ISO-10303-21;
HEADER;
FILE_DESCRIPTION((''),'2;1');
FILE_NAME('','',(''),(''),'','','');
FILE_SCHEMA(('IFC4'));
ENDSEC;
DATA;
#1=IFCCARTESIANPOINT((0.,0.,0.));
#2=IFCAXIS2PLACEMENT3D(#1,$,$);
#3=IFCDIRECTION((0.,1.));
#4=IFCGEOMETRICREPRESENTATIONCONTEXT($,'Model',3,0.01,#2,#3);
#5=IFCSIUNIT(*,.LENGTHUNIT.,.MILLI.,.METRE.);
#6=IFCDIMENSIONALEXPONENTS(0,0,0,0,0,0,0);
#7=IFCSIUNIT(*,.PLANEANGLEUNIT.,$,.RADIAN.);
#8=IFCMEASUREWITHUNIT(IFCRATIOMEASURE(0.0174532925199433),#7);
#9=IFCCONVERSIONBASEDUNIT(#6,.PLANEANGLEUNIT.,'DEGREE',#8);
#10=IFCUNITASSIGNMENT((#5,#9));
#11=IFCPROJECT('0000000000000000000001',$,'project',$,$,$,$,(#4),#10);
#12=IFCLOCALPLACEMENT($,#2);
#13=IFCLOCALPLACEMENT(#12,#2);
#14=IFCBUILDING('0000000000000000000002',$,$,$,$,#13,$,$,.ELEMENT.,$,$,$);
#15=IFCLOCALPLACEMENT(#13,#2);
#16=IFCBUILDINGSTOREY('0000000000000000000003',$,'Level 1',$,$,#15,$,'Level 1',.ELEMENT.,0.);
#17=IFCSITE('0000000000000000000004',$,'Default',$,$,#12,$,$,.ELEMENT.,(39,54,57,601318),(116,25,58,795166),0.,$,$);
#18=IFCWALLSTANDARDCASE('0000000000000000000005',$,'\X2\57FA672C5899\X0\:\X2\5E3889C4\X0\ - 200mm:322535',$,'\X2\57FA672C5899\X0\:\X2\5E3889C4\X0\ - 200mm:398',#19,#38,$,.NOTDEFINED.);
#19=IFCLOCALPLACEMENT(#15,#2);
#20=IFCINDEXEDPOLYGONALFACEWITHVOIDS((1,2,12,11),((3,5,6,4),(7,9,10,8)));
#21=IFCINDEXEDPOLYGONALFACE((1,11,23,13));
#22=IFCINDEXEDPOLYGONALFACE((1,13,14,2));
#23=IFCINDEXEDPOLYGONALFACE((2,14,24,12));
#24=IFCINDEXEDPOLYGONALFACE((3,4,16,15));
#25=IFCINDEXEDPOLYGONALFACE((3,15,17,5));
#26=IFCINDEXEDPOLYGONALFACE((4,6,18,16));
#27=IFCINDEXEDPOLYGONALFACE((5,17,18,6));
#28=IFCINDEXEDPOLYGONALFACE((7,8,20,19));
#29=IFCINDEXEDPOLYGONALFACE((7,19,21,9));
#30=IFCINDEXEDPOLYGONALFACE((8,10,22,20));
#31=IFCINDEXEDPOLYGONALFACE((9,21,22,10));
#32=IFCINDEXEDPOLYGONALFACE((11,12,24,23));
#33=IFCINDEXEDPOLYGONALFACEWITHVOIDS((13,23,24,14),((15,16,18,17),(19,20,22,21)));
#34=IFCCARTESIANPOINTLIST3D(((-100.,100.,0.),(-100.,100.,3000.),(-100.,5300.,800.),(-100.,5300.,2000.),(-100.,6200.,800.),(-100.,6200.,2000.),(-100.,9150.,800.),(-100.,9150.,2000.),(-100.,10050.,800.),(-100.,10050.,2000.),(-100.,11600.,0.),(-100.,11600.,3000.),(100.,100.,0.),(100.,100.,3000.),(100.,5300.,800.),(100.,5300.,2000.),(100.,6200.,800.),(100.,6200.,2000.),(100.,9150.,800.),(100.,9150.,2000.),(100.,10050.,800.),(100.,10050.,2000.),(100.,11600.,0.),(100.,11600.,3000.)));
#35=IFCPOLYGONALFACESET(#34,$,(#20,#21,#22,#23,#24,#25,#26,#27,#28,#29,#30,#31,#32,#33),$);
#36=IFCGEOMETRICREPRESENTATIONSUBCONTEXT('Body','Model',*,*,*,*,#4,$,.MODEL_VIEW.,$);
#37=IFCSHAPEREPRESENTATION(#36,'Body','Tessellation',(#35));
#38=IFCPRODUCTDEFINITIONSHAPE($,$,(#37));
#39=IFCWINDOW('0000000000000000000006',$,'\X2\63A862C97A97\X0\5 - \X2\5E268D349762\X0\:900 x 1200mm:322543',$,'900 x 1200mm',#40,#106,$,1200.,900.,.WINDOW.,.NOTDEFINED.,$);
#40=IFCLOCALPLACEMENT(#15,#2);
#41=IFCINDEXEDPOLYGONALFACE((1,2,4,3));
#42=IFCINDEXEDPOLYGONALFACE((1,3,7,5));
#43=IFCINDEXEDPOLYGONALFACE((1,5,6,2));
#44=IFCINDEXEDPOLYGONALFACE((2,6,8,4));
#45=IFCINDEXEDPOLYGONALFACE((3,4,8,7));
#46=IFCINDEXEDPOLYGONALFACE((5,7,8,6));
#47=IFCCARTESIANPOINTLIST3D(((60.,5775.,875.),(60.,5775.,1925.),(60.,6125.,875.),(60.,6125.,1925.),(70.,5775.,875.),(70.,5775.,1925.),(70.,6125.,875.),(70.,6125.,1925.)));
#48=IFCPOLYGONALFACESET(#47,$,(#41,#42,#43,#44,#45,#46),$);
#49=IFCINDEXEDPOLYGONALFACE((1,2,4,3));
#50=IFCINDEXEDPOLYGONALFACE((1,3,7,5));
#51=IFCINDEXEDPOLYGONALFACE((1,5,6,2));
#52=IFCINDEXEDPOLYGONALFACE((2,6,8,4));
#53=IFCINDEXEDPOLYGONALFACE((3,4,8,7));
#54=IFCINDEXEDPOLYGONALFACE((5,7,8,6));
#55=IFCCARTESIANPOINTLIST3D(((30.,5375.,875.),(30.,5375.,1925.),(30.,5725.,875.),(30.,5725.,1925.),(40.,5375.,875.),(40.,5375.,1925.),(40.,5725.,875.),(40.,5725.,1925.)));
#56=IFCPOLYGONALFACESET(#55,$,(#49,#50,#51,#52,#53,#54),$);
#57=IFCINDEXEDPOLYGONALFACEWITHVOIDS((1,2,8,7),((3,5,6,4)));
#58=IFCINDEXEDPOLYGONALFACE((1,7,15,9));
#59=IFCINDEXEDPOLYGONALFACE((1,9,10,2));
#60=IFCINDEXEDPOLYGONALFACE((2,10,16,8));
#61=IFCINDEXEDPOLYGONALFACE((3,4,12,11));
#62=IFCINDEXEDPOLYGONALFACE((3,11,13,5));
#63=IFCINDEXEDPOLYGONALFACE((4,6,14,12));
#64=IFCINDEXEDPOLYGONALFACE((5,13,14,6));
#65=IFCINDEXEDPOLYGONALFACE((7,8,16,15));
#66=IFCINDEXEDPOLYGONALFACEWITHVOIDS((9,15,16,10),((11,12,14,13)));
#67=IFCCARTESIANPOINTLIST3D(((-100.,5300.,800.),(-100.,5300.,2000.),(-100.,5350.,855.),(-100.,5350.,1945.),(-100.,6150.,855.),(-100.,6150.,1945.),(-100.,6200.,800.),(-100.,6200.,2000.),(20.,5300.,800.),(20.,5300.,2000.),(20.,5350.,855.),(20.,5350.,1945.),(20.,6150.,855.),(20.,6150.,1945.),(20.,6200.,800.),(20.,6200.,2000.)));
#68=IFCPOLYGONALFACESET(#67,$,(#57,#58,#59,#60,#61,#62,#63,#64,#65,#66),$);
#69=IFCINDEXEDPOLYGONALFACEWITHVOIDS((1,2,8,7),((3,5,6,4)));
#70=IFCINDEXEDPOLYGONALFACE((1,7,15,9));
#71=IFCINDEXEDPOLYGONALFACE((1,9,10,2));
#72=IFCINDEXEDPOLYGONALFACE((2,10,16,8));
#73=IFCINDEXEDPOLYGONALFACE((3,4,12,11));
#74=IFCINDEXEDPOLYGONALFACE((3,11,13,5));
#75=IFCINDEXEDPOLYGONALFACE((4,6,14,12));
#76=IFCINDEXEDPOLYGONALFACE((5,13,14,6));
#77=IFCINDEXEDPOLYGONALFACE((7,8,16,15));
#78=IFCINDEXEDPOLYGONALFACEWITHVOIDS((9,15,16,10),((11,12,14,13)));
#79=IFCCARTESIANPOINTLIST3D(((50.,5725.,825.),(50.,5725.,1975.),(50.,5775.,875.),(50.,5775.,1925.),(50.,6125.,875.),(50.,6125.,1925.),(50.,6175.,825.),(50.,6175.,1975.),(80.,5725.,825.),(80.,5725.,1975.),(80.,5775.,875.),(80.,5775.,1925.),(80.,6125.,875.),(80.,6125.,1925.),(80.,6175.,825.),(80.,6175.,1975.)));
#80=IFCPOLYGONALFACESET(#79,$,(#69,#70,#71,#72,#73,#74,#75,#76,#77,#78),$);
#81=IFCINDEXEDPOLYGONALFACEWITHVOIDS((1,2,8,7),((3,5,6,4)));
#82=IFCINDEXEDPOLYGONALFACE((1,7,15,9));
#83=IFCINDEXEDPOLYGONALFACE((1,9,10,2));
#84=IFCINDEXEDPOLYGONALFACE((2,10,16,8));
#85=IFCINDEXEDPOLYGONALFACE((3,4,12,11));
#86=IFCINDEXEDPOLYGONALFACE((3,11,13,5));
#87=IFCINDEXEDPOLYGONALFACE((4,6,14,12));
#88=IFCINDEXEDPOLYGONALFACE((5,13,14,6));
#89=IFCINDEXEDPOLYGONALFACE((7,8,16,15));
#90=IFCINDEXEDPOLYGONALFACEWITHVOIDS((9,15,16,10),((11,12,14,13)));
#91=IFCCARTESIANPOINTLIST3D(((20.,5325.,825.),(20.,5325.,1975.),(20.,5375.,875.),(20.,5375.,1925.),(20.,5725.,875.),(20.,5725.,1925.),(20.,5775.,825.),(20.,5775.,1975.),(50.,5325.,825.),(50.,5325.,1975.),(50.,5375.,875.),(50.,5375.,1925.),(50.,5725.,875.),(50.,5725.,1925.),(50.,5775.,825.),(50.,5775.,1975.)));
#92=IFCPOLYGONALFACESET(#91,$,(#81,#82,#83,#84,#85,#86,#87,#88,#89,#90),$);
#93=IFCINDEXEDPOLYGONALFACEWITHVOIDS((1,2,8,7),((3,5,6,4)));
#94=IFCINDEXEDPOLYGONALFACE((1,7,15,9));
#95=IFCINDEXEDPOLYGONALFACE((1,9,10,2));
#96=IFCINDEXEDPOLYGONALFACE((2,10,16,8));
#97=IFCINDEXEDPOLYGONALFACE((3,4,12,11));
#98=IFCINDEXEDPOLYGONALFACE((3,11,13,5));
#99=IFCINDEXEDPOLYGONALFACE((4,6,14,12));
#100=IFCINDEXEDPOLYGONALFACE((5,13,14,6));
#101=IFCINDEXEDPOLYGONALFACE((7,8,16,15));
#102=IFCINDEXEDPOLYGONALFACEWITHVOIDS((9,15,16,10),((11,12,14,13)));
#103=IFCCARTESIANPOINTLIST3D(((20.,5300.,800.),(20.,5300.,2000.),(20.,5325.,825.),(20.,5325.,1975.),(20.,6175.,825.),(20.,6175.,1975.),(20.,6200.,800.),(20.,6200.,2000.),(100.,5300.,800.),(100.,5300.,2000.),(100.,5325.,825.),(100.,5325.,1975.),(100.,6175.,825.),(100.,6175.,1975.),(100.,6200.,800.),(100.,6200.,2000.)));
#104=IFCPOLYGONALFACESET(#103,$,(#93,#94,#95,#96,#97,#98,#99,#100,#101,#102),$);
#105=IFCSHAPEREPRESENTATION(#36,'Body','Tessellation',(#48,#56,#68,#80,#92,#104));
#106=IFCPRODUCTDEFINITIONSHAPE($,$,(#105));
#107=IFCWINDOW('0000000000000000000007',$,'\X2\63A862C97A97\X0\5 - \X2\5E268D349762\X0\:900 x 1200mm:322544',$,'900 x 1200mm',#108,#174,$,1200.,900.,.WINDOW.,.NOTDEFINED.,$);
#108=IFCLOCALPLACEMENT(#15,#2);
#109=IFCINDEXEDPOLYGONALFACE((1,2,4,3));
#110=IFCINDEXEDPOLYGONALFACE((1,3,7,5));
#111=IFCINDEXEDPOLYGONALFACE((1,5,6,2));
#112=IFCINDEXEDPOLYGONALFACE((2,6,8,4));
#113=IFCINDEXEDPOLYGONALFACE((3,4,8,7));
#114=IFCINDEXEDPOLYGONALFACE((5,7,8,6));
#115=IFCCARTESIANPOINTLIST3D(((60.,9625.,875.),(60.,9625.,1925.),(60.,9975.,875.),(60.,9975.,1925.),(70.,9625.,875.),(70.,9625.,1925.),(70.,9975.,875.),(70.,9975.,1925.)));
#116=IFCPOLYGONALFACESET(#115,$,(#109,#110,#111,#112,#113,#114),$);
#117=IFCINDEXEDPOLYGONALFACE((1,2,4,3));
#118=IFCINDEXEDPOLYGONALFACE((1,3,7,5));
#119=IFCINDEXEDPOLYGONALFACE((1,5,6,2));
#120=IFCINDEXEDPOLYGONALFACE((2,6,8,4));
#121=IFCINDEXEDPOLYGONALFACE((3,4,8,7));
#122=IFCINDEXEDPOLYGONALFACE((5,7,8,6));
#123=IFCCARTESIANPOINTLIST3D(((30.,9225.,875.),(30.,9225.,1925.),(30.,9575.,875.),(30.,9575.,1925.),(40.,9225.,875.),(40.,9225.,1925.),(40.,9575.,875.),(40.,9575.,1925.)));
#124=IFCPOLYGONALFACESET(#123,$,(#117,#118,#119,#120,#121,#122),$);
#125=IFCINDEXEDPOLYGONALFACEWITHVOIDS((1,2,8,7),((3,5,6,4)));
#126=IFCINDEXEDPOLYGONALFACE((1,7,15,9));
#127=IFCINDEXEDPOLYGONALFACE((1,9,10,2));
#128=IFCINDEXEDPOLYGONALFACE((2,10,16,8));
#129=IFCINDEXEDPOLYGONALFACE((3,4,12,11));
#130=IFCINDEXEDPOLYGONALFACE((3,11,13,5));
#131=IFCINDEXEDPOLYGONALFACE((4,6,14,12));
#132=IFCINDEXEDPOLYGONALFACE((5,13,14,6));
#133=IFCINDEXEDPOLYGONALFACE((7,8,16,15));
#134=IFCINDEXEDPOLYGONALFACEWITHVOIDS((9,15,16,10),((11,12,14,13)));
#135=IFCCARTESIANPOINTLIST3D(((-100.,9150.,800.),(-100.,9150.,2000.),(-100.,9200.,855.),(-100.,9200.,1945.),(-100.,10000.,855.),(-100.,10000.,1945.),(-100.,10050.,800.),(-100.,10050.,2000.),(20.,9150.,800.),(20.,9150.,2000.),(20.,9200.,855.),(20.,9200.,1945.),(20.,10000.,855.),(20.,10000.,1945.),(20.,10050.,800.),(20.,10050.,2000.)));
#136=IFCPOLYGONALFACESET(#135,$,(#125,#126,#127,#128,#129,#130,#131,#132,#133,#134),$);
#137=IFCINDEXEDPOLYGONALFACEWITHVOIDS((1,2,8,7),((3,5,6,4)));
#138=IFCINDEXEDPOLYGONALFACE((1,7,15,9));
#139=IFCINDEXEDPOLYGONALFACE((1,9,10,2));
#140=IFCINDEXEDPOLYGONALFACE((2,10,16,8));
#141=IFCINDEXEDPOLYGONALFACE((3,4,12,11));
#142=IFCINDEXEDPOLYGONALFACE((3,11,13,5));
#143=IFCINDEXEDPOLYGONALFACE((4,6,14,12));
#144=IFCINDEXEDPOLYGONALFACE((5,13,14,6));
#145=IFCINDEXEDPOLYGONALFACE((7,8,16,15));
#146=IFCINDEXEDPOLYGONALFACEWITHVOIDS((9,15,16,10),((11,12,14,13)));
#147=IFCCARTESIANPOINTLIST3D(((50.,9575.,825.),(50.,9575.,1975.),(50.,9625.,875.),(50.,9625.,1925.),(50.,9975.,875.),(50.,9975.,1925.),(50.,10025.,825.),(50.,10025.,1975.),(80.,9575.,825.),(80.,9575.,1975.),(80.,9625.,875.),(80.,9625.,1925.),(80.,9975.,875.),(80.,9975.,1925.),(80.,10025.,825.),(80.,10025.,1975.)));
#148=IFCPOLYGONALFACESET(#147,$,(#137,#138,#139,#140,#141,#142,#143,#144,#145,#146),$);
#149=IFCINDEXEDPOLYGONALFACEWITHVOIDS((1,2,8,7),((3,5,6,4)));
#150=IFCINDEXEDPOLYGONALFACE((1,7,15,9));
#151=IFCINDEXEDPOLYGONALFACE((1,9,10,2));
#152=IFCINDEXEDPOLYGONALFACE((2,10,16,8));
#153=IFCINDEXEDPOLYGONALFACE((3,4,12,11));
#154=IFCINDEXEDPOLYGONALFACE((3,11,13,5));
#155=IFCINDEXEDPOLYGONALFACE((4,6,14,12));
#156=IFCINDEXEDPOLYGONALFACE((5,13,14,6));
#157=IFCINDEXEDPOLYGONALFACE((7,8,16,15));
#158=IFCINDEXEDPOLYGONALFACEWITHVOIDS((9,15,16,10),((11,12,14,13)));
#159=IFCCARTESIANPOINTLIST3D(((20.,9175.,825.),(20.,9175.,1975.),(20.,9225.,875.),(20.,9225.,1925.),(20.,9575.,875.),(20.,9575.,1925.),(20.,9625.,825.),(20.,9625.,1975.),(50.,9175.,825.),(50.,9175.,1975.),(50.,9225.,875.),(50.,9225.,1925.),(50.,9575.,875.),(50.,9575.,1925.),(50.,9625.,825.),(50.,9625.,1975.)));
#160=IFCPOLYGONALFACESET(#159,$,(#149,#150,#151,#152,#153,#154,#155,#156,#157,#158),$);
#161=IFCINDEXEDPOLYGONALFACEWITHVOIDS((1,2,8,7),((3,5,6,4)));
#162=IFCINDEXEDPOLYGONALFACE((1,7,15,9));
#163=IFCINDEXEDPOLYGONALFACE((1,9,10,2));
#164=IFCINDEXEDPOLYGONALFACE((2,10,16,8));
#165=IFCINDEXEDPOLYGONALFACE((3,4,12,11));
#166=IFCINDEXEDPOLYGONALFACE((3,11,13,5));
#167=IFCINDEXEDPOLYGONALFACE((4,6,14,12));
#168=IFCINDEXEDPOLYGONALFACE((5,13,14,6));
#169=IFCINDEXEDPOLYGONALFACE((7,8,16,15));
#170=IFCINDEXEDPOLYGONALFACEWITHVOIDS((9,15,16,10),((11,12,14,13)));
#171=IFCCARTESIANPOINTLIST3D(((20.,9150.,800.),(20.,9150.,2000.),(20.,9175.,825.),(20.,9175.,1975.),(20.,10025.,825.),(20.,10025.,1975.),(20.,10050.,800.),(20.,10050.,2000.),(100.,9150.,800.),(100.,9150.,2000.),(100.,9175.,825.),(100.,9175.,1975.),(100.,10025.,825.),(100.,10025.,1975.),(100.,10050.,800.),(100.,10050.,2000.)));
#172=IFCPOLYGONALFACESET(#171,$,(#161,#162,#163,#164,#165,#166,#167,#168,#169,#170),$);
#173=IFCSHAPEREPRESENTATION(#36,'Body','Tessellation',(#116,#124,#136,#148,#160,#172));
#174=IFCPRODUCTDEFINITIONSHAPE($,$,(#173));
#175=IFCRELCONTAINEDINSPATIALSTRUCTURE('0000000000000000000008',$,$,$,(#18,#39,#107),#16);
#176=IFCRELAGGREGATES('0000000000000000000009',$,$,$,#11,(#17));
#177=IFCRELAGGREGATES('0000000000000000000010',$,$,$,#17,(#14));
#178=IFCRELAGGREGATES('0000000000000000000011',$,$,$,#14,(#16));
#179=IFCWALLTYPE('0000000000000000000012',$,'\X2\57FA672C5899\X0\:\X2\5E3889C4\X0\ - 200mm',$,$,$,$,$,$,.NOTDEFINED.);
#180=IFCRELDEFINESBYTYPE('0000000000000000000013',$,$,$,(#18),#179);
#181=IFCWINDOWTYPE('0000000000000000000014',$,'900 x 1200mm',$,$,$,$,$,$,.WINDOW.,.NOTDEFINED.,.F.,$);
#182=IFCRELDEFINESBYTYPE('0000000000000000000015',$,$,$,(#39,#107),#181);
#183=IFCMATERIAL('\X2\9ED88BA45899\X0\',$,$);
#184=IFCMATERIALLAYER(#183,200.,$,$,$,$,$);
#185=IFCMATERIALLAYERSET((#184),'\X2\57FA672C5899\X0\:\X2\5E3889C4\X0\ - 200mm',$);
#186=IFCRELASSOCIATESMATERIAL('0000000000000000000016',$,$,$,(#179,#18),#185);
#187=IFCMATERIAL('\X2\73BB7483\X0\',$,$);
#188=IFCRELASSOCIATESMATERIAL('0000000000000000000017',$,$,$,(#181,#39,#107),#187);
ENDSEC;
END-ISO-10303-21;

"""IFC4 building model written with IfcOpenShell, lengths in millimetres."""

from ifc_helpers import new_model, entity, si_unit, converted_unit, direction, frame, frame_2d, origin, origin_2d_with_axis, place, context, subcontext, project, spatial, polyline, rectangle, outline, extrude, source, transform, mapped, material, layer, layer_set, layer_usage, type_object, type_shapes, element, fill, save


model = new_model("IFC4")

# Units and contexts
model_context = context("Model", 3, precision=0.01, world=origin(), true_north=direction((0.0, 1.0)))
body_context = subcontext(model_context, "Body", "Model", "MODEL_VIEW")
ifc_project = project(units=[si_unit("LENGTHUNIT", "METRE", prefix="MILLI"), converted_unit("PLANEANGLEUNIT", "DEGREE", entity("IfcRatioMeasure", 0.0174532925199433), si_unit("PLANEANGLEUNIT", "RADIAN"), dimensions=[0, 0, 0, 0, 0, 0, 0])], contexts=[model_context])

# Site, building, storey
site_placement = place(None, origin())
site = spatial("IfcSite", under=ifc_project, at=site_placement, Name="Default", CompositionType="ELEMENT", RefLatitude=(39, 54, 57, 601318), RefLongitude=(116, 25, 58, 795166), RefElevation=0.0)
building_placement = place(site_placement, origin())
building = spatial("IfcBuilding", under=site, at=building_placement, CompositionType="ELEMENT")
storey_placement = place(building_placement, origin())
storey = spatial("IfcBuildingStorey", under=building, at=storey_placement, Name="Level 1", LongName="Level 1", CompositionType="ELEMENT", Elevation=0.0)

# Shared definitions
ifc_material_1 = material(Name="默认墙")
ifc_layer_1 = layer(ifc_material_1, 200.0)
ifc_layer_set_1 = layer_set([ifc_layer_1], Name="基本墙:常规 - 200mm")
wall_type = type_object("IfcWallType", Name="基本墙:常规 - 200mm", PredefinedType="NOTDEFINED", material=ifc_layer_set_1)
ifc_material_2 = material(Name="玻璃")

# Wall, openings, windows
ifc_layer_usage_1 = layer_usage(ifc_layer_set_1, "AXIS2", "NEGATIVE", 100.0)
wall_1_placement = place(storey_placement, frame((0.0, 100.0, 0.0), z_axis=(0.0, 0.0, 1.0), x_axis=(0.0, 1.0, 0.0)))
wall_1 = element("IfcWallStandardCase", 1, at=wall_1_placement, inside=storey, type_object=wall_type, material=ifc_layer_usage_1, Name="基本墙:常规 - 200mm:322535", ObjectType="基本墙:常规 - 200mm:398", PredefinedType="NOTDEFINED", context=body_context, shape_type="SweptSolid", body=[
    extrude(rectangle(XDim=11500.0, YDim=200.0, at=frame_2d((5750.0, 0.0), x_axis=(-1.0, 0.0))), origin(), (0.0, 0.0, 1.0), 3000.0),
])
opening_1_placement = place(wall_1_placement, frame((6100.0, 100.0, 800.0)))
opening_1 = element("IfcOpeningElement", 2, at=opening_1_placement, cuts=wall_1, ObjectType="Opening", PredefinedType="OPENING", context=body_context, shape_type="SweptSolid", body=[
    extrude(rectangle(XDim=1200.0, YDim=900.0, at=frame_2d((600.0, 450.0), x_axis=(-1.0, 0.0))), frame((0.0, 0.0, 0.0), z_axis=(0.0, -1.0, 0.0), x_axis=(0.0, 0.0, 1.0)), (0.0, 0.0, 1.0), 200.0),
])
opening_2_placement = place(wall_1_placement, frame((9950.0, 100.0, 800.0)))
opening_2 = element("IfcOpeningElement", 3, at=opening_2_placement, cuts=wall_1, ObjectType="Opening", PredefinedType="OPENING", context=body_context, shape_type="SweptSolid", body=[
    extrude(rectangle(XDim=1200.0, YDim=900.0, at=frame_2d((600.0, 450.0), x_axis=(-1.0, 0.0))), frame((0.0, 0.0, 0.0), z_axis=(0.0, -1.0, 0.0), x_axis=(0.0, 0.0, 1.0)), (0.0, 0.0, 1.0), 200.0),
])
window_type_1 = type_object("IfcWindowType", Name="900 x 1200mm", ParameterTakesPrecedence=False, PartitioningType="NOTDEFINED", PredefinedType="WINDOW", material=ifc_material_2)
shared_shape_1 = source(origin(), body_context, "Body", "SweptSolid", [
    extrude(rectangle(XDim=10.0, YDim=350.0, at=origin_2d_with_axis()), frame((250.0, 165.0, 75.0), z_axis=(0.0, 0.0, 1.0), x_axis=(0.0, -1.0, 0.0)), (0.0, 0.0, 1.0), 1050.0),
    extrude(rectangle(XDim=10.0, YDim=350.0, at=origin_2d_with_axis()), frame((650.0, 135.0, 75.0), z_axis=(0.0, 0.0, 1.0), x_axis=(0.0, -1.0, 0.0)), (0.0, 0.0, 1.0), 1050.0),
    extrude(outline(polyline([(-450.0, -600.0), (450.0, -600.0), (450.0, 600.0), (-450.0, 600.0), (-450.0, -600.0)]), holes=[polyline([(400.0, -545.0), (-400.0, -545.0), (-400.0, 545.0), (400.0, 545.0), (400.0, -545.0)])]), frame((450.0, 0.0, 600.0), z_axis=(0.0, 1.0, 0.0), x_axis=(1.0, 0.0, 0.0)), (0.0, 0.0, 1.0), 120.0),
    extrude(outline(polyline([(-225.0, -575.0), (225.0, -575.0), (225.0, 575.0), (-225.0, 575.0), (-225.0, -575.0)]), holes=[polyline([(-175.0, -525.0), (-175.0, 525.0), (175.0, 525.0), (175.0, -525.0), (-175.0, -525.0)])]), frame((250.0, 150.0, 600.0), z_axis=(0.0, 1.0, 0.0), x_axis=(-1.0, 0.0, 0.0)), (0.0, 0.0, 1.0), 30.0),
    extrude(outline(polyline([(-225.0, -575.0), (225.0, -575.0), (225.0, 575.0), (-225.0, 575.0), (-225.0, -575.0)]), holes=[polyline([(-175.0, -525.0), (-175.0, 525.0), (175.0, 525.0), (175.0, -525.0), (-175.0, -525.0)])]), frame((650.0, 120.0, 600.0), z_axis=(0.0, 1.0, 0.0), x_axis=(1.0, 0.0, 0.0)), (0.0, 0.0, 1.0), 30.0),
    extrude(outline(polyline([(-450.0, -600.0), (450.0, -600.0), (450.0, 600.0), (-450.0, 600.0), (-450.0, -600.0)]), holes=[polyline([(-425.0, 575.0), (425.0, 575.0), (425.0, -575.0), (-425.0, -575.0), (-425.0, 575.0)])]), frame((450.0, 120.0, 600.0), z_axis=(0.0, 1.0, 0.0), x_axis=(1.0, 0.0, 0.0)), (0.0, 0.0, 1.0), 80.0),
])
type_shapes(window_type_1, [shared_shape_1])
window_1_placement = place(opening_1_placement, frame((0.0, 0.0, 0.0), z_axis=(0.0, 0.0, 1.0), x_axis=(-1.0, 0.0, 0.0)))
window_1 = element("IfcWindow", 4, at=window_1_placement, inside=storey, type_object=window_type_1, material=ifc_material_2, Name="推拉窗5 - 带贴面:900 x 1200mm:322543", ObjectType="900 x 1200mm", OverallHeight=1200.0, OverallWidth=900.0, PartitioningType="NOTDEFINED", PredefinedType="WINDOW", context=body_context, shape_type="MappedRepresentation", body=[
    mapped(shared_shape_1, transform((0.0, 0.0, 0.0), scale=1.0)),
])
fill(opening_1, window_1)
window_2_placement = place(opening_2_placement, frame((0.0, 0.0, 0.0), z_axis=(0.0, 0.0, 1.0), x_axis=(-1.0, 0.0, 0.0)))
window_2 = element("IfcWindow", 5, at=window_2_placement, inside=storey, type_object=window_type_1, material=ifc_material_2, Name="推拉窗5 - 带贴面:900 x 1200mm:322544", ObjectType="900 x 1200mm", OverallHeight=1200.0, OverallWidth=900.0, PartitioningType="NOTDEFINED", PredefinedType="WINDOW", context=body_context, shape_type="MappedRepresentation", body=[
    mapped(shared_shape_1, transform((0.0, 0.0, 0.0), scale=1.0)),
])
fill(opening_2, window_2)

save(model, "model.ifc")
